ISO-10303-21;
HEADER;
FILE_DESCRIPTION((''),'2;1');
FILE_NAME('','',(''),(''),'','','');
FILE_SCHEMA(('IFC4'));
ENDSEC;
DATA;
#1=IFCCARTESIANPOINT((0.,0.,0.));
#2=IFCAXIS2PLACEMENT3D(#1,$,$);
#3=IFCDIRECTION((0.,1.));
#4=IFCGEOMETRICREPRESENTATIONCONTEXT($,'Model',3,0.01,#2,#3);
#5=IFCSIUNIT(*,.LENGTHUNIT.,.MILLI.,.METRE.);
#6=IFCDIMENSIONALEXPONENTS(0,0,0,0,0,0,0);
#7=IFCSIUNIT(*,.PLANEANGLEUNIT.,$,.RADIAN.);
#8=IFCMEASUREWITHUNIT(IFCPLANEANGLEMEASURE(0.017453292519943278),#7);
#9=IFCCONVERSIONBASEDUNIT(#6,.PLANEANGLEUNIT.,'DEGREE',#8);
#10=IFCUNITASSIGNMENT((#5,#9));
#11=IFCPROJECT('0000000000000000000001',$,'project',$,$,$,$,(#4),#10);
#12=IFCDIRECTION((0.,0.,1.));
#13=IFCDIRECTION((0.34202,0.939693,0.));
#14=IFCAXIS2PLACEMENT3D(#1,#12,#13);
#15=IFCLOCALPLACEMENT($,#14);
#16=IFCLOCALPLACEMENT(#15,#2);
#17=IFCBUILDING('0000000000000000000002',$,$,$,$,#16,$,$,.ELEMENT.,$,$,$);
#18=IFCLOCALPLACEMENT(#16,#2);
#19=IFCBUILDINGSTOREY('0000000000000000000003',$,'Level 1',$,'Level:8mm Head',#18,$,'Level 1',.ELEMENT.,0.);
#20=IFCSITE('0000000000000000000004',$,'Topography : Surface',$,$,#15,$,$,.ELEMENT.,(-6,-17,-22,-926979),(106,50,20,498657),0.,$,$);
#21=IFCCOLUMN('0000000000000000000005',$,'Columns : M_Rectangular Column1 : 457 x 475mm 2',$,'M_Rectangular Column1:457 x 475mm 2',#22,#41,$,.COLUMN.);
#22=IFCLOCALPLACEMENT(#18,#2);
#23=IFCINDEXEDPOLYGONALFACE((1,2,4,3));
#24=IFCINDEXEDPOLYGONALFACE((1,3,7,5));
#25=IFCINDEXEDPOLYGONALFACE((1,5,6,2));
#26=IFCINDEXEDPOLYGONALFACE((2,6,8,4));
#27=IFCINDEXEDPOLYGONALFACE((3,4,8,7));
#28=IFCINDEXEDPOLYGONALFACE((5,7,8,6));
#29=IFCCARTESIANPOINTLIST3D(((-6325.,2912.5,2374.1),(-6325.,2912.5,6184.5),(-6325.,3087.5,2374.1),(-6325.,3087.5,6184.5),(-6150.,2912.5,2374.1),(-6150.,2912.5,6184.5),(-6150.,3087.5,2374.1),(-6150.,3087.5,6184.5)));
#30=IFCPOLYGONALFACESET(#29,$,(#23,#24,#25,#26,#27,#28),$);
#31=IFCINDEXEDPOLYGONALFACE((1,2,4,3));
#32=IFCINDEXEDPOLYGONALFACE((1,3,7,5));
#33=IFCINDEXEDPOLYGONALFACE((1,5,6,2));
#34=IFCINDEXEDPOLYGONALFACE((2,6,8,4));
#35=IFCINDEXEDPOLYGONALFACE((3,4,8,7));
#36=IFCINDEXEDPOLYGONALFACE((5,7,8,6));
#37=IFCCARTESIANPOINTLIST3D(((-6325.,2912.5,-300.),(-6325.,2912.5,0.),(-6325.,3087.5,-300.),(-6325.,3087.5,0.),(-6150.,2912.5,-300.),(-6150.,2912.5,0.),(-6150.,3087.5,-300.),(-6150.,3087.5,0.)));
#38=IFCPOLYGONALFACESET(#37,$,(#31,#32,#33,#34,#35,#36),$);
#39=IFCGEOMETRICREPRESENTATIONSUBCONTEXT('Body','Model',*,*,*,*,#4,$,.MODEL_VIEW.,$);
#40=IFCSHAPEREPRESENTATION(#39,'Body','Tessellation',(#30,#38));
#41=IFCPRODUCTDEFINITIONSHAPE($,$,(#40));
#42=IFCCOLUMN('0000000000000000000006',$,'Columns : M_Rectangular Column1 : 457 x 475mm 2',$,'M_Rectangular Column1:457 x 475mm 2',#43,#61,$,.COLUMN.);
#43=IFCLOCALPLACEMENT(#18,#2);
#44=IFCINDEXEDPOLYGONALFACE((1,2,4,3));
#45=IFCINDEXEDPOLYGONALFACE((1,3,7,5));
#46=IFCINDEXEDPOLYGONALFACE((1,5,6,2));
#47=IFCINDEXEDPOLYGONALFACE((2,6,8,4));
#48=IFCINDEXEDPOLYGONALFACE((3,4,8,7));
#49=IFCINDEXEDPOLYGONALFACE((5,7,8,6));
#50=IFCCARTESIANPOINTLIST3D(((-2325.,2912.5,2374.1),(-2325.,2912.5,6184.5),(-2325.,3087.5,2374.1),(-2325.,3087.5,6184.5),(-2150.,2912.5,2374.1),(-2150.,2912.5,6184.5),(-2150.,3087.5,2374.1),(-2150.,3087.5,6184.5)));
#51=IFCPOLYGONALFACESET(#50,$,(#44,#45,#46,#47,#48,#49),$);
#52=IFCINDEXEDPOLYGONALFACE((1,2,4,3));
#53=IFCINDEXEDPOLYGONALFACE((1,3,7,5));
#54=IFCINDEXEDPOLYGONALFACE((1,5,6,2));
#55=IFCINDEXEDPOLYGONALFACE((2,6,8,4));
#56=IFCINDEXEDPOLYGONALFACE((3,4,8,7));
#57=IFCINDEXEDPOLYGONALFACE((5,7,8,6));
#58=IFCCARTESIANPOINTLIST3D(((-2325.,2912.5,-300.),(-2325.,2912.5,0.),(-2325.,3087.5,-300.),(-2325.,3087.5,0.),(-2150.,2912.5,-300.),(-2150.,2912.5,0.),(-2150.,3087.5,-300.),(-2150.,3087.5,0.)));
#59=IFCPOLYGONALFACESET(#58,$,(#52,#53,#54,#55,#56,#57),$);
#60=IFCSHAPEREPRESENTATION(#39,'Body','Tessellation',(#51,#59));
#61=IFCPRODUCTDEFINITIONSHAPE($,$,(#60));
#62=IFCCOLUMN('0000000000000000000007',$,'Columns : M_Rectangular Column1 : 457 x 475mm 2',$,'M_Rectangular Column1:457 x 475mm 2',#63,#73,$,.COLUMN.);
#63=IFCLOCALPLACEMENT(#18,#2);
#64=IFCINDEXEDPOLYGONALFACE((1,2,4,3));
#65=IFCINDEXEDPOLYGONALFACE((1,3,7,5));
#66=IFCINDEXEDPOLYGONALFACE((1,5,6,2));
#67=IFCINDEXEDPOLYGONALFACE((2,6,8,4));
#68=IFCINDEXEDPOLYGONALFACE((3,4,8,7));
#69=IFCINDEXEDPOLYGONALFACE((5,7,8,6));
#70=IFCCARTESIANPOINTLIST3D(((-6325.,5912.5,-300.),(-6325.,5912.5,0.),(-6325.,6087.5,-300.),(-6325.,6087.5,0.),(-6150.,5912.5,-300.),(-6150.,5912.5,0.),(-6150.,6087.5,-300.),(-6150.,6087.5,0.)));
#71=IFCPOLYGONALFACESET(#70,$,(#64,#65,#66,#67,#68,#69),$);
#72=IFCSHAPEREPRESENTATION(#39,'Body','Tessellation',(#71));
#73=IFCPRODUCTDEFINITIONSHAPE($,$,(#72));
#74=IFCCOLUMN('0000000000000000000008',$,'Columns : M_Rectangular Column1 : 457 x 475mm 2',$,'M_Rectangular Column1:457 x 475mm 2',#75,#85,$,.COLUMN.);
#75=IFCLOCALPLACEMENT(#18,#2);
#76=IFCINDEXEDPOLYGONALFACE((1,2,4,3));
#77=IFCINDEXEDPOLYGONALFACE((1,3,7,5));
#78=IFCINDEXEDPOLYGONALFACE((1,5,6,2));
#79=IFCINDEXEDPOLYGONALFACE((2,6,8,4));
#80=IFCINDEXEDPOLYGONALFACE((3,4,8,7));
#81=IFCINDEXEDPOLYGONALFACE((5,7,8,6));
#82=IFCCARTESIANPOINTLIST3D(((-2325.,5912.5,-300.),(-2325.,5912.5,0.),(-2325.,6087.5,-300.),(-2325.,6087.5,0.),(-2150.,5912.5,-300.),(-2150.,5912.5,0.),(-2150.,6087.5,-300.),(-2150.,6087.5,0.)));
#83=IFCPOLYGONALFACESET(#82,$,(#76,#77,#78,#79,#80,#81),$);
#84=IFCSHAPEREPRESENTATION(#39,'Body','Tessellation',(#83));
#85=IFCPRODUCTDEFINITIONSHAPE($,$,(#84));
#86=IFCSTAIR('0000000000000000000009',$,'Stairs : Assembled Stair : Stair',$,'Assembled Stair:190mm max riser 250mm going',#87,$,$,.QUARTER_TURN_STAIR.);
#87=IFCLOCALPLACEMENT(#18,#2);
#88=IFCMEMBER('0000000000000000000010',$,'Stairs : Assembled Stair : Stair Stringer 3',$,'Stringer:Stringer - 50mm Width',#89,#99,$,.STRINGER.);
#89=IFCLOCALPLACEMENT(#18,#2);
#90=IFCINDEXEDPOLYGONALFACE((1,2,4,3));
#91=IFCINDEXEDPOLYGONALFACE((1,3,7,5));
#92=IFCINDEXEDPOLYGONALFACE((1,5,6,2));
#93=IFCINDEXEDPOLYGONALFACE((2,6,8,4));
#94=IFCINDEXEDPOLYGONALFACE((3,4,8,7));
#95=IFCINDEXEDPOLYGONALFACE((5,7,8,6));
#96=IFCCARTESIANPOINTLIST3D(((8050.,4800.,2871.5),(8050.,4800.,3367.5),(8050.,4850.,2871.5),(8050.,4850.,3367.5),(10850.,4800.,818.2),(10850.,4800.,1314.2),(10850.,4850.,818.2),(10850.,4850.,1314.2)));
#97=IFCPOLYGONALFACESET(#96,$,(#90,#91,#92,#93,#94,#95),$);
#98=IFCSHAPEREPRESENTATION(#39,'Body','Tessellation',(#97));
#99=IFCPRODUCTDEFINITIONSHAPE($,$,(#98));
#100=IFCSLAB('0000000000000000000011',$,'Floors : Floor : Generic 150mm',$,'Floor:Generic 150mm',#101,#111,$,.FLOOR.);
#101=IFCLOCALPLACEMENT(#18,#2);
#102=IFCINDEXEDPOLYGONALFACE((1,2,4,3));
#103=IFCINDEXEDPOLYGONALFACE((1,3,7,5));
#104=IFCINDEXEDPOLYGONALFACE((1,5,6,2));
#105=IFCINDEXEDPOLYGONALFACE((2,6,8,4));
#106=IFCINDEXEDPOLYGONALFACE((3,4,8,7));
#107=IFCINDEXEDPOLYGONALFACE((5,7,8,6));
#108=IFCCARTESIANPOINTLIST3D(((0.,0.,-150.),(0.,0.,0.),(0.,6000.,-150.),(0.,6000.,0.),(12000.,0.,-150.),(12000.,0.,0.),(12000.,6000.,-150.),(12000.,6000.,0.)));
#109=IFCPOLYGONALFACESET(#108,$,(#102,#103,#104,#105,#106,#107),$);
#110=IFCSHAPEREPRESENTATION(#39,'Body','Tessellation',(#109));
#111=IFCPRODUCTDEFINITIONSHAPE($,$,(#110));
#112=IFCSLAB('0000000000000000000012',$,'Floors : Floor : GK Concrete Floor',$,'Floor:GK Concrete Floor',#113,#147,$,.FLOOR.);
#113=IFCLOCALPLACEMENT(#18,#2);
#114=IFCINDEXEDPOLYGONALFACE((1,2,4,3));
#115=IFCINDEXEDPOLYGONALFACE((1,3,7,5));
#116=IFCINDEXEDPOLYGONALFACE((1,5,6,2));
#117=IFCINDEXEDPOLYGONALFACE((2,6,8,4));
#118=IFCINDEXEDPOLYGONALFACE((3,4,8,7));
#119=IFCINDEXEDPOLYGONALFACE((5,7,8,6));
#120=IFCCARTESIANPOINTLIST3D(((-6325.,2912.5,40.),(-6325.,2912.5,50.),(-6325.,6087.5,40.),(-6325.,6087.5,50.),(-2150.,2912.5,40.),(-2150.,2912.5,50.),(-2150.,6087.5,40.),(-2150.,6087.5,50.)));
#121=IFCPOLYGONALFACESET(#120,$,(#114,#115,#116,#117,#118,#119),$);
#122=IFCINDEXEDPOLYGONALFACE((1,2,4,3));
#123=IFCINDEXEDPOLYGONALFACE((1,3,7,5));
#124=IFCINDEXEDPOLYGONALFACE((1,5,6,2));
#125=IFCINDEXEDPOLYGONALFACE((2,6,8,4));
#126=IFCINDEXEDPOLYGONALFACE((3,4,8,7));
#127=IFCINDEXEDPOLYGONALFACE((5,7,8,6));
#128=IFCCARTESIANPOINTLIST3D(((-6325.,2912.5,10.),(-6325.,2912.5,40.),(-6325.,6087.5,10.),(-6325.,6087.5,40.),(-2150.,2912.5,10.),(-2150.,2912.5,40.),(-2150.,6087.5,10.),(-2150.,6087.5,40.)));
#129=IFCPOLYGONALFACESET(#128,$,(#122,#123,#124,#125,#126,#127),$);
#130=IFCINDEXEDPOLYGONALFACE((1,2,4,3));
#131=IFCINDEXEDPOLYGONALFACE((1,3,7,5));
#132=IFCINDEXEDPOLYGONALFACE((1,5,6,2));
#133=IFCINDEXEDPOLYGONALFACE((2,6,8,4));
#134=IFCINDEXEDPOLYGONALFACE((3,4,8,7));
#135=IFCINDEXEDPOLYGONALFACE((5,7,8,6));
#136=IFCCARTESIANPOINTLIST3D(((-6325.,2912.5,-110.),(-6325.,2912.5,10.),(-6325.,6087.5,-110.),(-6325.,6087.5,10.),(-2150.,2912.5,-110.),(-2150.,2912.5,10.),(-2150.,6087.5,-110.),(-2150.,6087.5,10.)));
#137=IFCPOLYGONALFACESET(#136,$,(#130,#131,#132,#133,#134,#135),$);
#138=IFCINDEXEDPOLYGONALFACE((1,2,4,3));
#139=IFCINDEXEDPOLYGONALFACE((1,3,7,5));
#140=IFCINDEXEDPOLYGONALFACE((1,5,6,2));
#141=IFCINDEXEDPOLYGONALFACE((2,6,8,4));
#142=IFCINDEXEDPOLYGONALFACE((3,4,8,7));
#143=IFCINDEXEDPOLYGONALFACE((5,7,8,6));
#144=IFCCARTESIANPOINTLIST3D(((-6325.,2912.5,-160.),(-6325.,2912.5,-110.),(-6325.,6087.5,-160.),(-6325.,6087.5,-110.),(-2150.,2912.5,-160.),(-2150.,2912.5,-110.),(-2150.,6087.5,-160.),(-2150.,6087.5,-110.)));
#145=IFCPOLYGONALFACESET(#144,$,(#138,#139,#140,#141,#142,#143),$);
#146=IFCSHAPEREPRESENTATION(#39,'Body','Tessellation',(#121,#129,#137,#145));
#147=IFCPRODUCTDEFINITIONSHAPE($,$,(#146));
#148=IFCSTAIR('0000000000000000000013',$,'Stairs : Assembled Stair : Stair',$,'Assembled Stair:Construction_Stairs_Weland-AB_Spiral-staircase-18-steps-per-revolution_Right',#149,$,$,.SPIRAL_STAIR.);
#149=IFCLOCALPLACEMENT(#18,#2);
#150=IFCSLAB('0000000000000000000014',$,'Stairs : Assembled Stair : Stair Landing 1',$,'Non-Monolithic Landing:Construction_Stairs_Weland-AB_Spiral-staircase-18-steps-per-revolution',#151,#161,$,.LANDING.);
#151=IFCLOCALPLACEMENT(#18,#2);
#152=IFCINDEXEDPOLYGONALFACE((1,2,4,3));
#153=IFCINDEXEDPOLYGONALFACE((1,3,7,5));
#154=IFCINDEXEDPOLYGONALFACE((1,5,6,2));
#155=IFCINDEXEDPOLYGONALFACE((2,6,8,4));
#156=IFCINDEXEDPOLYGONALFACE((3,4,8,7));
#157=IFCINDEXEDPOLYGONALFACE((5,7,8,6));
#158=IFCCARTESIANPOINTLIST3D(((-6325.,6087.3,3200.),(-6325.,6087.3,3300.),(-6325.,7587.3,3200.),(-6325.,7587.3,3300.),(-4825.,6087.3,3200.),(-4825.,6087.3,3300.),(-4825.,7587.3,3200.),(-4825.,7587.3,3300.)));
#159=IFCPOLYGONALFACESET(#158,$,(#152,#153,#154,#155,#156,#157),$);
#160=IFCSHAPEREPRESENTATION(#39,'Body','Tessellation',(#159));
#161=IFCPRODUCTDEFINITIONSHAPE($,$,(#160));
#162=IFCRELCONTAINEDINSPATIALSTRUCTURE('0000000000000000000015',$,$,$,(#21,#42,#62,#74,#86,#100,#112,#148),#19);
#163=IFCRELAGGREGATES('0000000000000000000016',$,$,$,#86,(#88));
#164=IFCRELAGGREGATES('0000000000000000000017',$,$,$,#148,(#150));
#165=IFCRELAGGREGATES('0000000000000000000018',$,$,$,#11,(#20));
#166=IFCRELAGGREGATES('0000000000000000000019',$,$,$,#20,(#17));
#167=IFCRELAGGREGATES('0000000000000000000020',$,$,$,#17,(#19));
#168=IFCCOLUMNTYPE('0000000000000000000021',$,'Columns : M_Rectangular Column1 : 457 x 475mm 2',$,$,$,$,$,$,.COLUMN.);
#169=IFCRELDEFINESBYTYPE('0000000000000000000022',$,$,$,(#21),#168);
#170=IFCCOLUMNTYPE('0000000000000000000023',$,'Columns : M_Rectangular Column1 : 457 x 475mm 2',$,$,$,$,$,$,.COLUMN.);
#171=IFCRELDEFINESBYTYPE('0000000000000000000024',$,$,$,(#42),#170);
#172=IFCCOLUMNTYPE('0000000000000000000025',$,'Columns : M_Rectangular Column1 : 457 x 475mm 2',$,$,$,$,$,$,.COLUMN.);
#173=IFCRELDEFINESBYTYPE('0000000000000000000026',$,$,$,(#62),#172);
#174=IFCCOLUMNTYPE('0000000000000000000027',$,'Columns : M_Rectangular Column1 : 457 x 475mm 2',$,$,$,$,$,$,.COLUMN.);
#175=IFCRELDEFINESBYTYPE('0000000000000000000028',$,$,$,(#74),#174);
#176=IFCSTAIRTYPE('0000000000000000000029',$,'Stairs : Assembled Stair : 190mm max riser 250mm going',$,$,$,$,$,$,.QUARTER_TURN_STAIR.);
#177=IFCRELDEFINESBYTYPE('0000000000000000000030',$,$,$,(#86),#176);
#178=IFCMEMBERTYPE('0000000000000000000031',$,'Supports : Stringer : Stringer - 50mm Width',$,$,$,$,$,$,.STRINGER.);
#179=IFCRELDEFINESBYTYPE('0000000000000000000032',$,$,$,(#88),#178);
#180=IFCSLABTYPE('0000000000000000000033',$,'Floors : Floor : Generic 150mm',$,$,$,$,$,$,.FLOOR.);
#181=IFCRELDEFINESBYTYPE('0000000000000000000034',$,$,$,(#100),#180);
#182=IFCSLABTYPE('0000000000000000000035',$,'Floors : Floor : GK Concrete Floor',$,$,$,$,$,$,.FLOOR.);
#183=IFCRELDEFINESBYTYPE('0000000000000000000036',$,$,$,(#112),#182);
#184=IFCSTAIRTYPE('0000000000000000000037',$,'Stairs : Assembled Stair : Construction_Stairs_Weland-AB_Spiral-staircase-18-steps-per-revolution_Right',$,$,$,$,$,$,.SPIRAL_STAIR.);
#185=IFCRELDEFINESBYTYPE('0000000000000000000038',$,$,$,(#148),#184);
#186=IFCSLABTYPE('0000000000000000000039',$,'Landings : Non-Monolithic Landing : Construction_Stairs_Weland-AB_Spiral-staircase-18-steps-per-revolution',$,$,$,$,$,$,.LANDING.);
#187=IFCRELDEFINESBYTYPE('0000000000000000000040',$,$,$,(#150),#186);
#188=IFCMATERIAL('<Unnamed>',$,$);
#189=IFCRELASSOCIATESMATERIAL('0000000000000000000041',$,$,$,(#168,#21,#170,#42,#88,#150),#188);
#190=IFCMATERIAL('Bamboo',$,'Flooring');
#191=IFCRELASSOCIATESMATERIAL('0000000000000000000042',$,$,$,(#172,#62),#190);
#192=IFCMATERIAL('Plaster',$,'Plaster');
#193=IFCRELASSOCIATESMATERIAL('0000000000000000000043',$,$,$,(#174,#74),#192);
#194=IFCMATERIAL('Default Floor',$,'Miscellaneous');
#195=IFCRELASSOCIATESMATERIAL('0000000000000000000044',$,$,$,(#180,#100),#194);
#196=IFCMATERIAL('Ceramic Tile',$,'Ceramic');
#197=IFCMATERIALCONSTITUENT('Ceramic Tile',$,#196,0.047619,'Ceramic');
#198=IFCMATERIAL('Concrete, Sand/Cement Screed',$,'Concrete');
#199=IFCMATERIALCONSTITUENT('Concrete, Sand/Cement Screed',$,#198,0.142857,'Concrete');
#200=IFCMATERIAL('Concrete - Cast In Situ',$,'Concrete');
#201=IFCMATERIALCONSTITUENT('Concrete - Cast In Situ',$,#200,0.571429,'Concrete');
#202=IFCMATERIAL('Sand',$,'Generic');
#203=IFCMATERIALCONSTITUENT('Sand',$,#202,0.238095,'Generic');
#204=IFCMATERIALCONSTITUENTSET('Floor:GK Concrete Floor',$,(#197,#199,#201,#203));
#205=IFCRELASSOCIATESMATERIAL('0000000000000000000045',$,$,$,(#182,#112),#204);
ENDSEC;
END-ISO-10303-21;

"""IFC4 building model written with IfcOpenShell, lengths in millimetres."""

from ifc_helpers import new_model, entity, si_unit, converted_unit, direction, frame, origin, place, context, subcontext, project, spatial, indexed_curve, outline, extrude, source, transform, mapped, material, constituent, constituent_set, type_object, type_shapes, element, aggregate, save


model = new_model("IFC4")

# Units and contexts
model_context = context("Model", 3, precision=0.01, world=origin(), true_north=direction((0.0, 1.0)))
body_context = subcontext(model_context, "Body", "Model", "MODEL_VIEW")
ifc_project = project(units=[si_unit("LENGTHUNIT", "METRE", prefix="MILLI"), converted_unit("PLANEANGLEUNIT", "DEGREE", entity("IfcPlaneAngleMeasure", 0.017453292519943278), si_unit("PLANEANGLEUNIT", "RADIAN"), dimensions=[0, 0, 0, 0, 0, 0, 0])], contexts=[model_context])

# Site, building, storey
site_placement = place(None, frame((0.0, 0.0, 0.0), z_axis=(0.0, 0.0, 1.0), x_axis=(0.34202, 0.939693, 0.0)))
site = spatial("IfcSite", under=ifc_project, at=site_placement, Name="Topography : Surface", CompositionType="ELEMENT", RefLatitude=(-6, -17, -22, -926979), RefLongitude=(106, 50, 20, 498657), RefElevation=0.0)
building_placement = place(site_placement, origin())
building = spatial("IfcBuilding", under=site, at=building_placement, CompositionType="ELEMENT")
storey_placement = place(building_placement, origin())
storey = spatial("IfcBuildingStorey", under=building, at=storey_placement, Name="Level 1", ObjectType="Level:8mm Head", LongName="Level 1", CompositionType="ELEMENT", Elevation=0.0)

# Columns
ifc_material_1 = material(Name="<Unnamed>")
column_type_1 = type_object("IfcColumnType", Name="Columns : M_Rectangular Column1 : 457 x 475mm 2", PredefinedType="COLUMN", material=ifc_material_1)
shared_shape_1 = source(origin(), body_context, "Body", "SweptSolid", [
    extrude(outline(indexed_curve([(-87.5, -87.5), (87.5, -87.5), (87.5, 87.5), (-87.5, 87.5), (-87.5, -87.5)], self_intersect=False)), frame((-6237.5, 3000.0, 2374.1), z_axis=(0.0, 0.0, 1.0), x_axis=(0.0, 1.0, 0.0)), (0.0, 0.0, 1.0), 3810.4),
    extrude(outline(indexed_curve([(-87.5, -87.5), (87.5, -87.5), (87.5, 87.5), (-87.5, 87.5), (-87.5, -87.5)], self_intersect=False)), frame((-6237.5, 3000.0, -300.0), z_axis=(0.0, 0.0, 1.0), x_axis=(-1.0, 0.0, 0.0)), (0.0, 0.0, 1.0), 300.0),
])
type_shapes(column_type_1, [shared_shape_1])
column_1_placement = place(storey_placement, origin())
element("IfcColumn", 1, at=column_1_placement, inside=storey, type_object=column_type_1, material=ifc_material_1, Name="Columns : M_Rectangular Column1 : 457 x 475mm 2", ObjectType="M_Rectangular Column1:457 x 475mm 2", PredefinedType="COLUMN", context=body_context, shape_type="MappedRepresentation", body=[
    mapped(shared_shape_1, transform((0.0, 0.0, 0.0), scale=1.0)),
])
column_type_2 = type_object("IfcColumnType", Name="Columns : M_Rectangular Column1 : 457 x 475mm 2", PredefinedType="COLUMN", material=ifc_material_1)
shared_shape_2 = source(origin(), body_context, "Body", "SweptSolid", [
    extrude(outline(indexed_curve([(-87.5, -87.5), (87.5, -87.5), (87.5, 87.5), (-87.5, 87.5), (-87.5, -87.5)], self_intersect=False)), frame((-2237.5, 3000.0, 2374.1), z_axis=(0.0, 0.0, 1.0), x_axis=(0.0, 1.0, 0.0)), (0.0, 0.0, 1.0), 3810.4),
    extrude(outline(indexed_curve([(-87.5, -87.5), (87.5, -87.5), (87.5, 87.5), (-87.5, 87.5), (-87.5, -87.5)], self_intersect=False)), frame((-2237.5, 3000.0, -300.0), z_axis=(0.0, 0.0, 1.0), x_axis=(-1.0, 0.0, 0.0)), (0.0, 0.0, 1.0), 300.0),
])
type_shapes(column_type_2, [shared_shape_2])
column_2_placement = place(storey_placement, origin())
element("IfcColumn", 2, at=column_2_placement, inside=storey, type_object=column_type_2, material=ifc_material_1, Name="Columns : M_Rectangular Column1 : 457 x 475mm 2", ObjectType="M_Rectangular Column1:457 x 475mm 2", PredefinedType="COLUMN", context=body_context, shape_type="MappedRepresentation", body=[
    mapped(shared_shape_2, transform((0.0, 0.0, 0.0), scale=1.0)),
])
ifc_material_2 = material(Name="Bamboo", Category="Flooring")
column_type_3 = type_object("IfcColumnType", Name="Columns : M_Rectangular Column1 : 457 x 475mm 2", PredefinedType="COLUMN", material=ifc_material_2)
shared_shape_3 = source(origin(), body_context, "Body", "SweptSolid", [
    extrude(outline(indexed_curve([(-87.5, -87.5), (87.5, -87.5), (87.5, 87.5), (-87.5, 87.5), (-87.5, -87.5)], self_intersect=False)), frame((-6237.5, 6000.0, -300.0), z_axis=(0.0, 0.0, 1.0), x_axis=(-1.0, 0.0, 0.0)), (0.0, 0.0, 1.0), 300.0),
])
type_shapes(column_type_3, [shared_shape_3])
column_3_placement = place(storey_placement, origin())
element("IfcColumn", 3, at=column_3_placement, inside=storey, type_object=column_type_3, material=ifc_material_2, Name="Columns : M_Rectangular Column1 : 457 x 475mm 2", ObjectType="M_Rectangular Column1:457 x 475mm 2", PredefinedType="COLUMN", context=body_context, shape_type="MappedRepresentation", body=[
    mapped(shared_shape_3, transform((0.0, 0.0, 0.0), scale=1.0)),
])
ifc_material_3 = material(Name="Plaster", Category="Plaster")
column_type_4 = type_object("IfcColumnType", Name="Columns : M_Rectangular Column1 : 457 x 475mm 2", PredefinedType="COLUMN", material=ifc_material_3)
shared_shape_4 = source(origin(), body_context, "Body", "SweptSolid", [
    extrude(outline(indexed_curve([(-87.5, -87.5), (87.5, -87.5), (87.5, 87.5), (-87.5, 87.5), (-87.5, -87.5)], self_intersect=False)), frame((-2237.5, 6000.0, -300.0), z_axis=(0.0, 0.0, 1.0), x_axis=(-1.0, 0.0, 0.0)), (0.0, 0.0, 1.0), 300.0),
])
type_shapes(column_type_4, [shared_shape_4])
column_4_placement = place(storey_placement, origin())
element("IfcColumn", 4, at=column_4_placement, inside=storey, type_object=column_type_4, material=ifc_material_3, Name="Columns : M_Rectangular Column1 : 457 x 475mm 2", ObjectType="M_Rectangular Column1:457 x 475mm 2", PredefinedType="COLUMN", context=body_context, shape_type="MappedRepresentation", body=[
    mapped(shared_shape_4, transform((0.0, 0.0, 0.0), scale=1.0)),
])

# Stair, member
stair_type_1 = type_object("IfcStairType", Name="Stairs : Assembled Stair : 190mm max riser 250mm going", PredefinedType="QUARTER_TURN_STAIR")
stair_1_placement = place(storey_placement, origin())
stair_1 = element("IfcStair", 5, at=stair_1_placement, inside=storey, type_object=stair_type_1, Name="Stairs : Assembled Stair : Stair", ObjectType="Assembled Stair:190mm max riser 250mm going", PredefinedType="QUARTER_TURN_STAIR")
member_type = type_object("IfcMemberType", Name="Supports : Stringer : Stringer - 50mm Width", PredefinedType="STRINGER")
member_1_placement = place(stair_1_placement, frame((8050.0, 4800.0, 818.2)))
member_1 = element("IfcMember", 6, at=member_1_placement, type_object=member_type, material=ifc_material_1, Name="Stairs : Assembled Stair : Stair Stringer 3", ObjectType="Stringer:Stringer - 50mm Width", PredefinedType="STRINGER", context=body_context, shape_type="SweptSolid", body=[
    extrude(outline(indexed_curve([(-1882.8, -200.0), (1589.4, -200.0), (1882.8, 200.0), (-1589.4, 200.0), (-1882.8, -200.0)], self_intersect=False)), frame((1400.0, 0.0, 1274.7), z_axis=(0.0, 1.0, 0.0), x_axis=(-0.806405, 0.0, 0.591364)), (0.0, 0.0, 1.0), 50.0),
])

# Slabs
ifc_material_4 = material(Name="Default Floor", Category="Miscellaneous")
slab_type_1 = type_object("IfcSlabType", Name="Floors : Floor : Generic 150mm", PredefinedType="FLOOR", material=ifc_material_4)
slab_1_placement = place(storey_placement, origin())
element("IfcSlab", 7, at=slab_1_placement, inside=storey, type_object=slab_type_1, material=ifc_material_4, Name="Floors : Floor : Generic 150mm", ObjectType="Floor:Generic 150mm", PredefinedType="FLOOR", context=body_context, shape_type="SweptSolid", body=[
    extrude(outline(indexed_curve([(-3000.0, -6000.0), (3000.0, -6000.0), (3000.0, 6000.0), (-3000.0, 6000.0), (-3000.0, -6000.0)], self_intersect=False)), frame((6000.0, 3000.0, 0.0), z_axis=(0.0, 0.0, -1.0), x_axis=(0.0, 1.0, 0.0)), (0.0, 0.0, 1.0), 150.0),
])
ifc_material_5 = material(Name="Ceramic Tile", Category="Ceramic")
ifc_constituent_1 = constituent(ifc_material_5, Name="Ceramic Tile", Category="Ceramic", fraction=0.047619)
ifc_material_6 = material(Name="Concrete, Sand/Cement Screed", Category="Concrete")
ifc_constituent_2 = constituent(ifc_material_6, Name="Concrete, Sand/Cement Screed", Category="Concrete", fraction=0.142857)
ifc_material_7 = material(Name="Concrete - Cast In Situ", Category="Concrete")
ifc_constituent_3 = constituent(ifc_material_7, Name="Concrete - Cast In Situ", Category="Concrete", fraction=0.571429)
ifc_material_8 = material(Name="Sand", Category="Generic")
ifc_constituent_4 = constituent(ifc_material_8, Name="Sand", Category="Generic", fraction=0.238095)
ifc_constituent_set_1 = constituent_set(constituents=[ifc_constituent_1, ifc_constituent_2, ifc_constituent_3, ifc_constituent_4], Name="Floor:GK Concrete Floor")
slab_type_2 = type_object("IfcSlabType", Name="Floors : Floor : GK Concrete Floor", PredefinedType="FLOOR", material=ifc_constituent_set_1)
slab_2_placement = place(storey_placement, origin())
element("IfcSlab", 8, at=slab_2_placement, inside=storey, type_object=slab_type_2, material=ifc_constituent_set_1, Name="Floors : Floor : GK Concrete Floor", ObjectType="Floor:GK Concrete Floor", PredefinedType="FLOOR", context=body_context, shape_type="SweptSolid", body=[
    extrude(outline(indexed_curve([(-2087.5, -1587.5), (2087.5, -1587.5), (2087.5, 1587.5), (-2087.5, 1587.5), (-2087.5, -1587.5)], self_intersect=False)), frame((-4237.5, 4500.0, 40.0), z_axis=(0.0, 0.0, 1.0), x_axis=(-1.0, 0.0, 0.0)), (0.0, 0.0, 1.0), 10.0),
    extrude(outline(indexed_curve([(-2087.5, -1587.5), (2087.5, -1587.5), (2087.5, 1587.5), (-2087.5, 1587.5), (-2087.5, -1587.5)], self_intersect=False)), frame((-4237.5, 4500.0, 10.0), z_axis=(0.0, 0.0, 1.0), x_axis=(-1.0, 0.0, 0.0)), (0.0, 0.0, 1.0), 30.0),
    extrude(outline(indexed_curve([(-2087.5, -1587.5), (2087.5, -1587.5), (2087.5, 1587.5), (-2087.5, 1587.5), (-2087.5, -1587.5)], self_intersect=False)), frame((-4237.5, 4500.0, -110.0), z_axis=(0.0, 0.0, 1.0), x_axis=(-1.0, 0.0, 0.0)), (0.0, 0.0, 1.0), 120.0),
    extrude(outline(indexed_curve([(-2087.5, -1587.5), (2087.5, -1587.5), (2087.5, 1587.5), (-2087.5, 1587.5), (-2087.5, -1587.5)], self_intersect=False)), frame((-4237.5, 4500.0, -160.0), z_axis=(0.0, 0.0, 1.0), x_axis=(-1.0, 0.0, 0.0)), (0.0, 0.0, 1.0), 50.0),
])

# Stair, slab
stair_type_2 = type_object("IfcStairType", Name="Stairs : Assembled Stair : Construction_Stairs_Weland-AB_Spiral-staircase-18-steps-per-revolution_Right", PredefinedType="SPIRAL_STAIR")
stair_2_placement = place(storey_placement, origin())
stair_2 = element("IfcStair", 9, at=stair_2_placement, inside=storey, type_object=stair_type_2, Name="Stairs : Assembled Stair : Stair", ObjectType="Assembled Stair:Construction_Stairs_Weland-AB_Spiral-staircase-18-steps-per-revolution_Right", PredefinedType="SPIRAL_STAIR")
slab_type_3 = type_object("IfcSlabType", Name="Landings : Non-Monolithic Landing : Construction_Stairs_Weland-AB_Spiral-staircase-18-steps-per-revolution", PredefinedType="LANDING")
slab_3_placement = place(stair_2_placement, frame((-6325.0, 6087.3, 0.0)))
slab_3 = element("IfcSlab", 10, at=slab_3_placement, type_object=slab_type_3, material=ifc_material_1, Name="Stairs : Assembled Stair : Stair Landing 1", ObjectType="Non-Monolithic Landing:Construction_Stairs_Weland-AB_Spiral-staircase-18-steps-per-revolution", PredefinedType="LANDING", context=body_context, shape_type="SweptSolid", body=[
    extrude(outline(indexed_curve([(-750.0, -750.0), (750.0, -750.0), (750.0, 750.0), (-750.0, 750.0), (-750.0, -750.0)], self_intersect=False)), frame((750.0, 750.0, 3200.0), z_axis=(0.0, 0.0, 1.0), x_axis=(0.0, 1.0, 0.0)), (0.0, 0.0, 1.0), 100.0),
])

aggregate(stair_1, [member_1])
aggregate(stair_2, [slab_3])

save(model, "model.ifc")
